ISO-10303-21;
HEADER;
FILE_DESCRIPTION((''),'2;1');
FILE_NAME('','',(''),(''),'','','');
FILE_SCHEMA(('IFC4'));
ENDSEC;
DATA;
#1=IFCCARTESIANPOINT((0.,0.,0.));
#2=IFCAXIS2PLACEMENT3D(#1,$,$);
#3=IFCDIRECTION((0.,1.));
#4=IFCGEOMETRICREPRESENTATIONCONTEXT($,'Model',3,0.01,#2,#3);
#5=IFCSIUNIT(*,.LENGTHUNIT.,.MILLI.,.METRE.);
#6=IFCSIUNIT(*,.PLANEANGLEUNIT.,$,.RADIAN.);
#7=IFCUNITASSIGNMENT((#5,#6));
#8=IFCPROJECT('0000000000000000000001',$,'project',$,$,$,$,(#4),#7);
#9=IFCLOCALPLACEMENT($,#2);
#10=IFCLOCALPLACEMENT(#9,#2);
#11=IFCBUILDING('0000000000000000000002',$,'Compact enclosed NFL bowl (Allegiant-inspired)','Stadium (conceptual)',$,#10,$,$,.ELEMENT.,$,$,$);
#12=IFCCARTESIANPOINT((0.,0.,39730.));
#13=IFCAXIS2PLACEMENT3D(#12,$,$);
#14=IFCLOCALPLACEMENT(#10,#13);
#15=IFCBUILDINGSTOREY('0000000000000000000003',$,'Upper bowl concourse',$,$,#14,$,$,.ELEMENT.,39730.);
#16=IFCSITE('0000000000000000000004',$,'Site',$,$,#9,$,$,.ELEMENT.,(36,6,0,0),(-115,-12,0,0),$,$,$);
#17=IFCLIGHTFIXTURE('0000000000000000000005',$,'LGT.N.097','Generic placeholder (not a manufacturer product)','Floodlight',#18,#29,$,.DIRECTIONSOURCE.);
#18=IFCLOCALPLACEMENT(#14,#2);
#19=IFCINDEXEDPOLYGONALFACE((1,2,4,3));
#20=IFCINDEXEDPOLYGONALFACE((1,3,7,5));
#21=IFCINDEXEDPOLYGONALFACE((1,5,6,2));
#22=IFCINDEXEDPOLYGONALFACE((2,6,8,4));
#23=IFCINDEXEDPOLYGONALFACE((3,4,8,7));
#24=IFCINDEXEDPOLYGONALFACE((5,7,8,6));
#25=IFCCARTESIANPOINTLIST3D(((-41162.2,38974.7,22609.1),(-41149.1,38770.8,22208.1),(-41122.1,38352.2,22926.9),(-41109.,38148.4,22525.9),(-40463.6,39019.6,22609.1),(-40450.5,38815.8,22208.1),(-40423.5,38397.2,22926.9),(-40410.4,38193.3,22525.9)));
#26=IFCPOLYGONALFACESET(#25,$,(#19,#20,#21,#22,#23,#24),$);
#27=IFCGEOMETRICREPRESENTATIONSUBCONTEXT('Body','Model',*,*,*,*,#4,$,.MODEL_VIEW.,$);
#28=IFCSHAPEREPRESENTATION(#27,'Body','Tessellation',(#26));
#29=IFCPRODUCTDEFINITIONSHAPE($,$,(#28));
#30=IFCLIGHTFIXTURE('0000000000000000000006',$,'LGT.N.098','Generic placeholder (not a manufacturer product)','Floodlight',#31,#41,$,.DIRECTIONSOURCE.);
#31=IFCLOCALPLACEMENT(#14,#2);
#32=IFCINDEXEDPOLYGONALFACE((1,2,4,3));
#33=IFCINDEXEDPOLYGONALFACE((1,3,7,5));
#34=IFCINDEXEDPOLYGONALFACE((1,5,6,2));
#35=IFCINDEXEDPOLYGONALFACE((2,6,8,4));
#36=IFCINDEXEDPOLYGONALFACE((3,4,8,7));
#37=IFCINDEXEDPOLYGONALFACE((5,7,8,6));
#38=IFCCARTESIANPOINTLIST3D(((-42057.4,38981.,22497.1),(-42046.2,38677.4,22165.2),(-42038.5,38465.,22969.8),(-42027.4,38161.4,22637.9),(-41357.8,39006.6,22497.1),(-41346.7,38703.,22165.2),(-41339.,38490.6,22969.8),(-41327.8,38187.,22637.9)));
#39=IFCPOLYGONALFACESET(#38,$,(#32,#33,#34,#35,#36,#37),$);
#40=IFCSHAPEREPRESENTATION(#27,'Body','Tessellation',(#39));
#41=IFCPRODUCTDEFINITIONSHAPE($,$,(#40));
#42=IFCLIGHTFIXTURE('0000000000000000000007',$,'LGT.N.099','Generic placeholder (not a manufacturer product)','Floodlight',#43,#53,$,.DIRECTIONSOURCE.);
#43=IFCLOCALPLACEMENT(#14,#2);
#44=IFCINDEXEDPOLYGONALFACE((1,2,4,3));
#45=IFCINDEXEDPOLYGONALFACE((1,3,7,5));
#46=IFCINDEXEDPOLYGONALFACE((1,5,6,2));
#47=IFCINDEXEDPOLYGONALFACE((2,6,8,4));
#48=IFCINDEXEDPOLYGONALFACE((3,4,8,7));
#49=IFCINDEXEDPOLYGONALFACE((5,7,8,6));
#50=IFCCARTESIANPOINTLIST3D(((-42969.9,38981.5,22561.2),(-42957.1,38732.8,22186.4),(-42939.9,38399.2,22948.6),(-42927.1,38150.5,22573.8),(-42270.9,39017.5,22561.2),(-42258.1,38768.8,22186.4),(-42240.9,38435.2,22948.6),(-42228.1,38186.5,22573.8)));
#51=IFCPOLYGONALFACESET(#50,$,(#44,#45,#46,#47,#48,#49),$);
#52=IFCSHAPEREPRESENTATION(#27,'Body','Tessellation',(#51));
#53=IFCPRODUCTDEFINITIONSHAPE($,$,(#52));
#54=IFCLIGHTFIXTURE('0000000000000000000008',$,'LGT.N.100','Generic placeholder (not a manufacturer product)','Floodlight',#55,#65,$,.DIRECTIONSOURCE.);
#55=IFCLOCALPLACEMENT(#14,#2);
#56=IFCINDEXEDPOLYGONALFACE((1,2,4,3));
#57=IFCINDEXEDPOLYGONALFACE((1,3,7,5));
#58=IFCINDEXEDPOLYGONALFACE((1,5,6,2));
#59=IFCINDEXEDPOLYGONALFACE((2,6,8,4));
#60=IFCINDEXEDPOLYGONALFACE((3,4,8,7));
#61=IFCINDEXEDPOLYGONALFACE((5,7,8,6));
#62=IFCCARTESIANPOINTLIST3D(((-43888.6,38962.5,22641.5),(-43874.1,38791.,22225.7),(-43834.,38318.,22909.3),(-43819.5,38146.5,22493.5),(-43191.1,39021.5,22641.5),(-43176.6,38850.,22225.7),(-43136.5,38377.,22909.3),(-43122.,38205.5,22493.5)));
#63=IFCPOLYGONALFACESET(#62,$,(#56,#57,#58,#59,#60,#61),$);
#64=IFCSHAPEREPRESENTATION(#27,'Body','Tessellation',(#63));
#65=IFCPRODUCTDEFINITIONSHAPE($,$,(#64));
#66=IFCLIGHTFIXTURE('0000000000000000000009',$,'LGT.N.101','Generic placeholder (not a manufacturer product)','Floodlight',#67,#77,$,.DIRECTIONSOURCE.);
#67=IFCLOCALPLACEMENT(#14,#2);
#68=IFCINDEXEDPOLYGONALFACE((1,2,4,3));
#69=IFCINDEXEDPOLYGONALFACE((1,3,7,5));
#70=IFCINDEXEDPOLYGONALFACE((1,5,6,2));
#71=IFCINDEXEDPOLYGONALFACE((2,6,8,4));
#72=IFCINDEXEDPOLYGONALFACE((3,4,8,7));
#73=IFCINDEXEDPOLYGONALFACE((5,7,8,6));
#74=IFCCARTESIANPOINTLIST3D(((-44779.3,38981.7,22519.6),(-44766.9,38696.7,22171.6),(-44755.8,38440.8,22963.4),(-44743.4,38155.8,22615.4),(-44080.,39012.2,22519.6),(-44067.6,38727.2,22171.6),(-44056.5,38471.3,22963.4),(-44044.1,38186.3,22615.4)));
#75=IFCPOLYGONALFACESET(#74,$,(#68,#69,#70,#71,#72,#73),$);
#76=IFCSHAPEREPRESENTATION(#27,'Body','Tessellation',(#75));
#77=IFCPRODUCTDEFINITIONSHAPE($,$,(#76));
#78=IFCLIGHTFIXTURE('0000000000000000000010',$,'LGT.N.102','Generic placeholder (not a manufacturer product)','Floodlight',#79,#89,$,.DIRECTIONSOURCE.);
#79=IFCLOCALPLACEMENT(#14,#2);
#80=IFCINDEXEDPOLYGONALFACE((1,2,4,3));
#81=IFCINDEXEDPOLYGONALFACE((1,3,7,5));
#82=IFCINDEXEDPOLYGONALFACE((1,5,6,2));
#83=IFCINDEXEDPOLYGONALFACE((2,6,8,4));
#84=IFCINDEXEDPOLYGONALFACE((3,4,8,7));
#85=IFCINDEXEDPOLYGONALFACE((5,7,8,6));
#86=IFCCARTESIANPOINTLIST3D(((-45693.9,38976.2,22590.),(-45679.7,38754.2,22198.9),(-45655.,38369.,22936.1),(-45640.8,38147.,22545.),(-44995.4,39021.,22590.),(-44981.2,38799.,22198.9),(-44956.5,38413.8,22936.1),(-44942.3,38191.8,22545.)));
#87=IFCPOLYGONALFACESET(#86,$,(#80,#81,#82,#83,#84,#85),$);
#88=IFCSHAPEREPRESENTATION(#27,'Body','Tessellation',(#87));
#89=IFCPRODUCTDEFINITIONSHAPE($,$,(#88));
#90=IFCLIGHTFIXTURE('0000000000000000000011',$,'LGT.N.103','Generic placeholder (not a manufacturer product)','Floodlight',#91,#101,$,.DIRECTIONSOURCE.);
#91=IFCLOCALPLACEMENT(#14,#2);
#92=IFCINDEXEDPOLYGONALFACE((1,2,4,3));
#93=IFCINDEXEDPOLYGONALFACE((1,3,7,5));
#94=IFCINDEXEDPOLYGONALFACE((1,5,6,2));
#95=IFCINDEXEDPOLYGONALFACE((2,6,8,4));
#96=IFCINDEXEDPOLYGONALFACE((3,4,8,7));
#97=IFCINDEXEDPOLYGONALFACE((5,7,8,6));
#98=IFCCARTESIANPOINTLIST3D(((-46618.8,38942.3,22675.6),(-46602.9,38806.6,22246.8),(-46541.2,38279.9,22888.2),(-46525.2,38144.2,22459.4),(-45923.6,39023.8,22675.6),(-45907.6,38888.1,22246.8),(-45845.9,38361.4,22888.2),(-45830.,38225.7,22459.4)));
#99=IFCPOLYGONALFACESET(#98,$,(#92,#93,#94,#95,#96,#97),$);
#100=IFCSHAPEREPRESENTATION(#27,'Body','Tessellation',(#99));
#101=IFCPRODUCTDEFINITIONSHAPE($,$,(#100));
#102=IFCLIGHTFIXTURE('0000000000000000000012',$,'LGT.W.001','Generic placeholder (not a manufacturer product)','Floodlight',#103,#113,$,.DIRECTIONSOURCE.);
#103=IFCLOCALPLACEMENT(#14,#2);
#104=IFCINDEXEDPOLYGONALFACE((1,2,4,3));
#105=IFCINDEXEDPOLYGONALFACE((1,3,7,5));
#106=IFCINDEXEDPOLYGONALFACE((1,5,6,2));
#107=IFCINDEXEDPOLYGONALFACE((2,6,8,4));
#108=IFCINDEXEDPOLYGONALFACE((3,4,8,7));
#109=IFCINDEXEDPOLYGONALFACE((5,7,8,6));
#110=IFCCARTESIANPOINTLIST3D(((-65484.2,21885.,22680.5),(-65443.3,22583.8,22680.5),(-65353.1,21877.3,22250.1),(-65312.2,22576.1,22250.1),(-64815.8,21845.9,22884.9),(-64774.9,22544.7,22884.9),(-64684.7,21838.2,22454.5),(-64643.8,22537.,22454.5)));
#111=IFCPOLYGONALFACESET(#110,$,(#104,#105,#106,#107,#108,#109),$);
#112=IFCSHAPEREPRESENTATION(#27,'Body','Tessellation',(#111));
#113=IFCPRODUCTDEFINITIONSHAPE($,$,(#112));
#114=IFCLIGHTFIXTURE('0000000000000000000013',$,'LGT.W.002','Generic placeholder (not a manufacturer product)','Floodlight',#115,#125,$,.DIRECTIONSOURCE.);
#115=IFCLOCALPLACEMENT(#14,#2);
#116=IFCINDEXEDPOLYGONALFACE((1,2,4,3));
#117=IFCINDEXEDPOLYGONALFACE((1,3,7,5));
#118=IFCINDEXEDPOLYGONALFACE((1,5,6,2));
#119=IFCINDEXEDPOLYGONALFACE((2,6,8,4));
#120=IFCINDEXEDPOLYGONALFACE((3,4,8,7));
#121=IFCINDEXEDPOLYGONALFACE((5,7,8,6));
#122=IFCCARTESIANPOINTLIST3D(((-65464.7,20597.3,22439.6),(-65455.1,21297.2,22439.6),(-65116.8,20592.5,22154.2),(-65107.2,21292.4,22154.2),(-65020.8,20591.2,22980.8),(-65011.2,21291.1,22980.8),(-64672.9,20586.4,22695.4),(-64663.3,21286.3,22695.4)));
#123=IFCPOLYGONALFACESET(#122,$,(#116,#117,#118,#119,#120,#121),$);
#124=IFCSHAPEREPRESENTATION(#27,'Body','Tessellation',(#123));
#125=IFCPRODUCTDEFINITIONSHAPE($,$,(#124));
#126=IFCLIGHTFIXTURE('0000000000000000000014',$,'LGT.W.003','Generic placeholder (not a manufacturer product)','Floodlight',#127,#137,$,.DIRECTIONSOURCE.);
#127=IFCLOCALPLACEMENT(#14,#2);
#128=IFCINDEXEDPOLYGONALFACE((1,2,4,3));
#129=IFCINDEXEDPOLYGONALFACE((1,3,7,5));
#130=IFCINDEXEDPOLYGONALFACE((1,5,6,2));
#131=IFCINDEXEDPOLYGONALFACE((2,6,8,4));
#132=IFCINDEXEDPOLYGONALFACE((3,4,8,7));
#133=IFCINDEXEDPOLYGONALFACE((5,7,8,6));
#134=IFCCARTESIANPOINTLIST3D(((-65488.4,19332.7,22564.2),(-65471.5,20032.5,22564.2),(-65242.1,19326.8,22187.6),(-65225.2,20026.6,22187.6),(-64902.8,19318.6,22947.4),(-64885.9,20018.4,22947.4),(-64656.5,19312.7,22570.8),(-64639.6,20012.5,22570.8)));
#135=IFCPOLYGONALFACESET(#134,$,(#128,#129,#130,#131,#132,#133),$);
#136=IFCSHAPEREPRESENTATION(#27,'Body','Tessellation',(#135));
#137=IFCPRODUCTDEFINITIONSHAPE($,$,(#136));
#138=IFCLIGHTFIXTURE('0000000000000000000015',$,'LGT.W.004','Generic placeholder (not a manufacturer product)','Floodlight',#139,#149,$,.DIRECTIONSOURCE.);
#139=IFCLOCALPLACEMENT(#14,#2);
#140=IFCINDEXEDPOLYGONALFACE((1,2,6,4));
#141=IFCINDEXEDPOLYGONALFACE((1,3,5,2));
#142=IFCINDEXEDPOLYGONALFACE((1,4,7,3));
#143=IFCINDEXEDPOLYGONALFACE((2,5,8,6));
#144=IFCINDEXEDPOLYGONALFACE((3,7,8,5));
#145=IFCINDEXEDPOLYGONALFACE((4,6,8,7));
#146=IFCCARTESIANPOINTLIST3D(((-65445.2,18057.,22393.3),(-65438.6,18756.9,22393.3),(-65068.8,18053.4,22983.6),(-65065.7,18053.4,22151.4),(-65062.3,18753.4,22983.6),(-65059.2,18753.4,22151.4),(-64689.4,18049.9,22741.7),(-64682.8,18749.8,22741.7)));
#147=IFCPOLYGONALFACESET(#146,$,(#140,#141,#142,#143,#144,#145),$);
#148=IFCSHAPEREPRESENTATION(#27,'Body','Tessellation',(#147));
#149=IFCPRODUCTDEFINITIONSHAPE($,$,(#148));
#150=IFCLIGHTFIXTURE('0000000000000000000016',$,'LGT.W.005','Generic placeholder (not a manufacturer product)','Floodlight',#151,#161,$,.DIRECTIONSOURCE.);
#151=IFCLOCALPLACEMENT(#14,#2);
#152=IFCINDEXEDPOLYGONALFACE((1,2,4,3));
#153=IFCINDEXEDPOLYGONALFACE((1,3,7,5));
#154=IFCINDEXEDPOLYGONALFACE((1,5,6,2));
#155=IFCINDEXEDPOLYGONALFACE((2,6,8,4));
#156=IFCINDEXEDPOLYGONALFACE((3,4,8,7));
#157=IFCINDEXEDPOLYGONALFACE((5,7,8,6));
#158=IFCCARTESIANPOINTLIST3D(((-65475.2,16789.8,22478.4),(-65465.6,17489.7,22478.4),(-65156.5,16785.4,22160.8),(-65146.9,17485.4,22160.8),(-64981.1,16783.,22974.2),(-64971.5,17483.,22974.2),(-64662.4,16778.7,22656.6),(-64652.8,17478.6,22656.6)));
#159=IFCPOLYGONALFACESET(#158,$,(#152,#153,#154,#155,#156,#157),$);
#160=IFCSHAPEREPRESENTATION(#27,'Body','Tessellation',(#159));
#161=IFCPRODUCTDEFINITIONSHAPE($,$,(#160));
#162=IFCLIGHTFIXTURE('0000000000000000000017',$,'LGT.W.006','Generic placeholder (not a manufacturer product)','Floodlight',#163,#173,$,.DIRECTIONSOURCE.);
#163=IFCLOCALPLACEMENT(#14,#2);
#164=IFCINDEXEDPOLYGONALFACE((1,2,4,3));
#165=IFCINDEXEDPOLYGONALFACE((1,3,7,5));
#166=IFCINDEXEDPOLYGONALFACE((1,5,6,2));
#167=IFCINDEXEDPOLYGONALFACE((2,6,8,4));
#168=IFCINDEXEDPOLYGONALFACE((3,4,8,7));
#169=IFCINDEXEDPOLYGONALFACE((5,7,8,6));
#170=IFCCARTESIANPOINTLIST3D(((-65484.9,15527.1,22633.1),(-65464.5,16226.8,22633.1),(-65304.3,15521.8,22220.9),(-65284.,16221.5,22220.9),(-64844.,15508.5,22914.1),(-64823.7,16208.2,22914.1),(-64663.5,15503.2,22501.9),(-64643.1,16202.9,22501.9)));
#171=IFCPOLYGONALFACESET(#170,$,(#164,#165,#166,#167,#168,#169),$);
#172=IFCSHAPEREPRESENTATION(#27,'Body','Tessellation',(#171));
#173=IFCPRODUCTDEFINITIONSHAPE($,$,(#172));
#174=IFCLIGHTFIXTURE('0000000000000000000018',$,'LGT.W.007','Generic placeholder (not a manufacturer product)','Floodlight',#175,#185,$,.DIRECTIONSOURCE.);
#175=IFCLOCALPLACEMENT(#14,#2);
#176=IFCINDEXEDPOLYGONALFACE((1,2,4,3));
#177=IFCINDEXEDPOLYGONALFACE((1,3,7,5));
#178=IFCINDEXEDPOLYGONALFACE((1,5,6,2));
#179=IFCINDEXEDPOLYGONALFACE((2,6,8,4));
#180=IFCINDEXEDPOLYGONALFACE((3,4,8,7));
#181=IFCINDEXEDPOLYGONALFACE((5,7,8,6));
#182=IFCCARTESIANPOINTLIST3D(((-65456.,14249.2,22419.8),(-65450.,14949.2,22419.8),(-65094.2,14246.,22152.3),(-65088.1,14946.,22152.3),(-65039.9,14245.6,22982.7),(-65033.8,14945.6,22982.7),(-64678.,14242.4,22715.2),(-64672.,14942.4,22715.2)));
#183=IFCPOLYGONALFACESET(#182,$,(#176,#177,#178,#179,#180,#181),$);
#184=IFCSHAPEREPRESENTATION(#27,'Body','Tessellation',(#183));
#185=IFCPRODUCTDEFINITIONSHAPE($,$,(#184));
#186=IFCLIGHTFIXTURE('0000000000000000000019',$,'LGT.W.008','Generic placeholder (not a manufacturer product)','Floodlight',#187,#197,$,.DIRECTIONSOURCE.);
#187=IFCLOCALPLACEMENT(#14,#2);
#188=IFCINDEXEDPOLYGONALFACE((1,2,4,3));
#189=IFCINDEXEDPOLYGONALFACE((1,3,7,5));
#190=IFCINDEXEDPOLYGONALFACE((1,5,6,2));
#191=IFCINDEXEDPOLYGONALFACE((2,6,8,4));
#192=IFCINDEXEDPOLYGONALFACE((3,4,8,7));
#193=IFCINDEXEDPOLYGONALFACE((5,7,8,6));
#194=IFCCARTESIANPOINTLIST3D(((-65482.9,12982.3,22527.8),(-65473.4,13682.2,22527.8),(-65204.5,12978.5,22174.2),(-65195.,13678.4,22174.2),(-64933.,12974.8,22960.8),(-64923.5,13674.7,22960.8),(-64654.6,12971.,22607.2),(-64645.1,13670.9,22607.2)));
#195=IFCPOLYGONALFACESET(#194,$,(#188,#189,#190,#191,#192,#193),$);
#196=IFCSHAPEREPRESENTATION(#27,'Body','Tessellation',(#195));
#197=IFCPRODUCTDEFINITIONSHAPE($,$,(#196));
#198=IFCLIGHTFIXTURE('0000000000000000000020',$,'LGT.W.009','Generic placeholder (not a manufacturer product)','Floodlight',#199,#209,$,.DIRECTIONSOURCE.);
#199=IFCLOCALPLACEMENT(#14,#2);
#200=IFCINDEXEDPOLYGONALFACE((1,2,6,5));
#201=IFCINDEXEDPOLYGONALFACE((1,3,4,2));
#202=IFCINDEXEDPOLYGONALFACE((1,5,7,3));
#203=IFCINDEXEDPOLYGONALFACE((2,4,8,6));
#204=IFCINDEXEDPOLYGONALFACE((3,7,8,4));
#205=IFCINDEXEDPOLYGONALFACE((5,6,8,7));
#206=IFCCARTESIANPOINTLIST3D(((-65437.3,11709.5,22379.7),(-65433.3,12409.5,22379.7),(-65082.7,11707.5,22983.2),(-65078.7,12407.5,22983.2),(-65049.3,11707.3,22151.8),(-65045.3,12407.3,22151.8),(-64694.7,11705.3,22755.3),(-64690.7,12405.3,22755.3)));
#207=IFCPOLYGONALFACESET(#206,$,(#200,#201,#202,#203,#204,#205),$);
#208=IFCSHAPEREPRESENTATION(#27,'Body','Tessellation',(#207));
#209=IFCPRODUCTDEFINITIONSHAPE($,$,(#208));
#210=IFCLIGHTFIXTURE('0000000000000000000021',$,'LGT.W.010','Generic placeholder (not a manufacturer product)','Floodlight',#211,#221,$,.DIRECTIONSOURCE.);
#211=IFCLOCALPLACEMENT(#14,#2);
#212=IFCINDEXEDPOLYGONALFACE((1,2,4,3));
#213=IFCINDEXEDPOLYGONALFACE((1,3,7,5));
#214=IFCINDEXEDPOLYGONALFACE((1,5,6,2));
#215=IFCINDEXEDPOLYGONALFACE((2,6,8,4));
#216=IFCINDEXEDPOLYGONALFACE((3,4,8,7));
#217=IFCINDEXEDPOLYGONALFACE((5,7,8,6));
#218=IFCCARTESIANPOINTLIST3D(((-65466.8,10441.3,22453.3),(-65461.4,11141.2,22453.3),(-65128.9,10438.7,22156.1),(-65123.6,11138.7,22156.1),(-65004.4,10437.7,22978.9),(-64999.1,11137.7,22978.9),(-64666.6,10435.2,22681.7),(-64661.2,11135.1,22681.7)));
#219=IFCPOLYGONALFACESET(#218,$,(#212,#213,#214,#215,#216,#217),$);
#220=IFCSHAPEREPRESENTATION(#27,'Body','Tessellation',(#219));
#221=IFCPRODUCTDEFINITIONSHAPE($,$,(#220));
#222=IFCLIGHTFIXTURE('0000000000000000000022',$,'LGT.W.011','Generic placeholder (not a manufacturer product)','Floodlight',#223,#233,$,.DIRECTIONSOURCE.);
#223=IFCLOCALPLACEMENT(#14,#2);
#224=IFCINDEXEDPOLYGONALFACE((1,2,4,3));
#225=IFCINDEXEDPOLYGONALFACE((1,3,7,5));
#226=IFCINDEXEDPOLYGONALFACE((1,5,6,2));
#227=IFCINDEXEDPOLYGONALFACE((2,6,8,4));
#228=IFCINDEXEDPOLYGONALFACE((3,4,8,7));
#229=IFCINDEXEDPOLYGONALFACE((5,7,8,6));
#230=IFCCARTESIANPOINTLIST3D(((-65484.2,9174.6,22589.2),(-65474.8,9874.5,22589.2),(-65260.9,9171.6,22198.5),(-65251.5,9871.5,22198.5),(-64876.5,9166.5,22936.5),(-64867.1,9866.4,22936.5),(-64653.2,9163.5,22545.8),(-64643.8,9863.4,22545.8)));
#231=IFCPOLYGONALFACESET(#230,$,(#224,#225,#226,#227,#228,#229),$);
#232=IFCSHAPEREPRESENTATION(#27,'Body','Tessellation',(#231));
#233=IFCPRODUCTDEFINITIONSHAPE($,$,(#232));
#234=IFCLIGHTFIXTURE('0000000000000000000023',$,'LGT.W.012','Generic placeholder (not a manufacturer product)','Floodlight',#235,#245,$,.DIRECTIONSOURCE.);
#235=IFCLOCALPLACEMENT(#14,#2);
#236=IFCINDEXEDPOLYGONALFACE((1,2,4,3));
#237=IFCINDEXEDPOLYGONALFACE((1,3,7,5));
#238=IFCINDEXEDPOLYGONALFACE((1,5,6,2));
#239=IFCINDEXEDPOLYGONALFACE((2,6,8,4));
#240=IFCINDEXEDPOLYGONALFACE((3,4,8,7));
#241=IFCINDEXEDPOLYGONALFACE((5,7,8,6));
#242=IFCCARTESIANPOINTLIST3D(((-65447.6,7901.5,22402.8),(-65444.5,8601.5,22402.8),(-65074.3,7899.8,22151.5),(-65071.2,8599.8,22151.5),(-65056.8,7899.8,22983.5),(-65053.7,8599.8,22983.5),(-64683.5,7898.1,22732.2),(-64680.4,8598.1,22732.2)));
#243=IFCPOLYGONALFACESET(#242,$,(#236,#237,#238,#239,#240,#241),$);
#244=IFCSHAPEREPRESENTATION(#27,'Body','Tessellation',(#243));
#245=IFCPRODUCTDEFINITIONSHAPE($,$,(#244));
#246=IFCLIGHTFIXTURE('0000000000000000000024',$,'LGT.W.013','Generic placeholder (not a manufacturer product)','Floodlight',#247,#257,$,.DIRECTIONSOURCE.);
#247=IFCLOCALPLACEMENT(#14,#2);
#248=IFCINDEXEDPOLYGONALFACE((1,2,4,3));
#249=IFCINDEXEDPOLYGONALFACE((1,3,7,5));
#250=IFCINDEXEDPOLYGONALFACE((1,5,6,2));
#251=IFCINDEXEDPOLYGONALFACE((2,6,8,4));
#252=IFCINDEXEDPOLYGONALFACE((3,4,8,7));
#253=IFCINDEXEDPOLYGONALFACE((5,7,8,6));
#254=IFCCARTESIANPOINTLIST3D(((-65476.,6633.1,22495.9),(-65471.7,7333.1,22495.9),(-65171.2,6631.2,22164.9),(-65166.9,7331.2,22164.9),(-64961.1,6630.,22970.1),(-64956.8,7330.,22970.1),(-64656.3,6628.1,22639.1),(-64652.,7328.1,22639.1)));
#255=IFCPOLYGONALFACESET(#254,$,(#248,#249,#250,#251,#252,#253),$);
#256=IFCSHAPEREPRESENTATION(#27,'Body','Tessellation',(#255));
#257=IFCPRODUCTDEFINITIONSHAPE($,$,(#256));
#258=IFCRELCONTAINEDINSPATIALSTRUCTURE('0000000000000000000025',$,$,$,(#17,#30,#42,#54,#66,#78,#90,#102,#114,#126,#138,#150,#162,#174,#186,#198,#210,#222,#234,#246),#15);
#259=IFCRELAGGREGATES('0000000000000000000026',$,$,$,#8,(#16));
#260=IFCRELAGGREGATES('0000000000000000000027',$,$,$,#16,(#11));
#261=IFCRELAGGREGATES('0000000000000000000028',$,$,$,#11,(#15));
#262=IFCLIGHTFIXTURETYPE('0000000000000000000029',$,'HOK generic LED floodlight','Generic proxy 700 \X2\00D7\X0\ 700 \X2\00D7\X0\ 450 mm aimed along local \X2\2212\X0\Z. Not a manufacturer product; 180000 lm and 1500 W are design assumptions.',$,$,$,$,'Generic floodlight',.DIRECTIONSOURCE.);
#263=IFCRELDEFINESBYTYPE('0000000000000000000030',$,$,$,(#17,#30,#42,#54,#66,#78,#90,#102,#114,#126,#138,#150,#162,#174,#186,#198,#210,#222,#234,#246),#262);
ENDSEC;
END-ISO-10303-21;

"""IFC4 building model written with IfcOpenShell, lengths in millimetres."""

from ifc_helpers import new_model, si_unit, direction, frame, origin, place, context, subcontext, project, spatial, rectangle, extrude, source, transform, mapped, type_object, type_shapes, element, save


model = new_model("IFC4")

# Units and contexts
model_context = context("Model", 3, precision=0.01, world=origin(), true_north=direction((0.0, 1.0)))
body_context = subcontext(model_context, "Body", "Model", "MODEL_VIEW")
ifc_project = project(units=[si_unit("LENGTHUNIT", "METRE", prefix="MILLI"), si_unit("PLANEANGLEUNIT", "RADIAN")], contexts=[model_context])

# Site, building, storey
site_placement = place(None, origin())
site = spatial("IfcSite", under=ifc_project, at=site_placement, Name="Site", CompositionType="ELEMENT", RefLatitude=(36, 6, 0, 0), RefLongitude=(-115, -12, 0, 0))
building_placement = place(site_placement, origin())
building = spatial("IfcBuilding", under=site, at=building_placement, Name="Compact enclosed NFL bowl (Allegiant-inspired)", Description="Stadium (conceptual)", CompositionType="ELEMENT")
storey_placement = place(building_placement, frame((0.0, 0.0, 39730.0)))
storey = spatial("IfcBuildingStorey", under=building, at=storey_placement, Name="Upper bowl concourse", CompositionType="ELEMENT", Elevation=39730.0)

# Light fixtures
light_fixture_type = type_object("IfcLightFixtureType", Name="HOK generic LED floodlight", Description="Generic proxy 700 × 700 × 450 mm aimed along local −Z. Not a manufacturer product; 180000 lm and 1500 W are design assumptions.", ElementType="Generic floodlight", PredefinedType="DIRECTIONSOURCE")
shared_shape = source(origin(), body_context, "Body", "SweptSolid", [
    extrude(rectangle(XDim=700.0, YDim=700.0), frame((0.0, 0.0, -225.0)), (0.0, 0.0, 1.0), 450.0),
])
type_shapes(light_fixture_type, [shared_shape])
for number, where, z_axis, x_axis, name in (
    (1, (-40786.3, 38584.0, 22567.5), (-0.029168, 0.452997, 0.891035), (-0.997933, -0.064256, 0.0), "LGT.N.097"),
    (2, (-41692.6, 38584.0, 22567.5), (-0.024683, 0.674769, 0.737616), (-0.999332, -0.036555, 0.0), "LGT.N.098"),
    (3, (-42599.0, 38584.0, 22567.5), (-0.028476, 0.552721, 0.83288), (-0.998675, -0.051452, 0.0), "LGT.N.099"),
    (4, (-43505.3, 38584.0, 22567.5), (-0.032263, 0.381097, 0.923972), (-0.996436, -0.084356, 0.0), "LGT.N.100"),
    (5, (-44411.7, 38584.0, 22567.5), (-0.027568, 0.63331, 0.773407), (-0.999054, -0.043489, 0.0), "LGT.N.101"),
    (6, (-45318.1, 38584.0, 22567.5), (-0.031615, 0.493437, 0.869206), (-0.997954, -0.06394, 0.0), "LGT.N.102"),
    (7, (-46224.4, 38584.0, 22567.5), (-0.035348, 0.301573, 0.952788), (-0.993201, -0.116416, 0.0), "LGT.N.103"),
    (8, (-65064.0, 22211.0, 22567.5), (-0.291374, 0.01705, 0.956457), (-0.058417, -0.998292, 0.0), "LGT.W.001"),
    (9, (-65064.0, 20941.8, 22567.5), (-0.773104, 0.010659, 0.634189), (-0.013786, -0.999905, 0.0), "LGT.W.002"),
    (10, (-65064.0, 19672.6, 22567.5), (-0.547239, 0.013214, 0.836872), (-0.024139, -0.999709, 0.0), "LGT.W.003"),
    (11, (-65064.0, 18403.4, 22567.5), (-0.843152, 0.007941, 0.537616), (-0.009418, -0.999956, 0.0), "LGT.W.004"),
    (12, (-65064.0, 17134.2, 22567.5), (-0.708196, 0.009708, 0.705949), (-0.013707, -0.999906, 0.0), "LGT.W.005"),
    (13, (-65064.0, 15865.0, 22567.5), (-0.401213, 0.011663, 0.91591), (-0.029056, -0.999578, 0.0), "LGT.W.006"),
    (14, (-65064.0, 14595.8, 22567.5), (-0.804054, 0.006965, 0.594515), (-0.008661, -0.999962, 0.0), "LGT.W.007"),
    (15, (-65064.0, 13326.6, 22567.5), (-0.61858, 0.008404, 0.785677), (-0.013584, -0.999908, 0.0), "LGT.W.008"),
    (16, (-65064.0, 12057.4, 22567.5), (-0.862149, 0.004903, 0.506632), (-0.005687, -0.999984, 0.0), "LGT.W.009"),
    (17, (-65064.0, 10788.2, 22567.5), (-0.750767, 0.005719, 0.660542), (-0.007618, -0.999971, 0.0), "LGT.W.010"),
    (18, (-65064.0, 9519.0, 22567.5), (-0.496148, 0.006633, 0.868213), (-0.013368, -0.999911, 0.0), "LGT.W.011"),
    (19, (-65064.0, 8249.8, 22567.5), (-0.829608, 0.003697, 0.558334), (-0.004456, -0.99999, 0.0), "LGT.W.012"),
    (20, (-65064.0, 6980.6, 22567.5), (-0.677342, 0.004122, 0.735657), (-0.006085, -0.999981, 0.0), "LGT.W.013"),
):
    element("IfcLightFixture", number, at=place(storey_placement, frame(where, z_axis=z_axis, x_axis=x_axis)), inside=storey, type_object=light_fixture_type, Name=name, Description="Generic placeholder (not a manufacturer product)", ObjectType="Floodlight", PredefinedType="DIRECTIONSOURCE", context=body_context, shape_type="MappedRepresentation", body=[
        mapped(shared_shape, transform((0.0, 0.0, 0.0))),
    ])

save(model, "model.ifc")
